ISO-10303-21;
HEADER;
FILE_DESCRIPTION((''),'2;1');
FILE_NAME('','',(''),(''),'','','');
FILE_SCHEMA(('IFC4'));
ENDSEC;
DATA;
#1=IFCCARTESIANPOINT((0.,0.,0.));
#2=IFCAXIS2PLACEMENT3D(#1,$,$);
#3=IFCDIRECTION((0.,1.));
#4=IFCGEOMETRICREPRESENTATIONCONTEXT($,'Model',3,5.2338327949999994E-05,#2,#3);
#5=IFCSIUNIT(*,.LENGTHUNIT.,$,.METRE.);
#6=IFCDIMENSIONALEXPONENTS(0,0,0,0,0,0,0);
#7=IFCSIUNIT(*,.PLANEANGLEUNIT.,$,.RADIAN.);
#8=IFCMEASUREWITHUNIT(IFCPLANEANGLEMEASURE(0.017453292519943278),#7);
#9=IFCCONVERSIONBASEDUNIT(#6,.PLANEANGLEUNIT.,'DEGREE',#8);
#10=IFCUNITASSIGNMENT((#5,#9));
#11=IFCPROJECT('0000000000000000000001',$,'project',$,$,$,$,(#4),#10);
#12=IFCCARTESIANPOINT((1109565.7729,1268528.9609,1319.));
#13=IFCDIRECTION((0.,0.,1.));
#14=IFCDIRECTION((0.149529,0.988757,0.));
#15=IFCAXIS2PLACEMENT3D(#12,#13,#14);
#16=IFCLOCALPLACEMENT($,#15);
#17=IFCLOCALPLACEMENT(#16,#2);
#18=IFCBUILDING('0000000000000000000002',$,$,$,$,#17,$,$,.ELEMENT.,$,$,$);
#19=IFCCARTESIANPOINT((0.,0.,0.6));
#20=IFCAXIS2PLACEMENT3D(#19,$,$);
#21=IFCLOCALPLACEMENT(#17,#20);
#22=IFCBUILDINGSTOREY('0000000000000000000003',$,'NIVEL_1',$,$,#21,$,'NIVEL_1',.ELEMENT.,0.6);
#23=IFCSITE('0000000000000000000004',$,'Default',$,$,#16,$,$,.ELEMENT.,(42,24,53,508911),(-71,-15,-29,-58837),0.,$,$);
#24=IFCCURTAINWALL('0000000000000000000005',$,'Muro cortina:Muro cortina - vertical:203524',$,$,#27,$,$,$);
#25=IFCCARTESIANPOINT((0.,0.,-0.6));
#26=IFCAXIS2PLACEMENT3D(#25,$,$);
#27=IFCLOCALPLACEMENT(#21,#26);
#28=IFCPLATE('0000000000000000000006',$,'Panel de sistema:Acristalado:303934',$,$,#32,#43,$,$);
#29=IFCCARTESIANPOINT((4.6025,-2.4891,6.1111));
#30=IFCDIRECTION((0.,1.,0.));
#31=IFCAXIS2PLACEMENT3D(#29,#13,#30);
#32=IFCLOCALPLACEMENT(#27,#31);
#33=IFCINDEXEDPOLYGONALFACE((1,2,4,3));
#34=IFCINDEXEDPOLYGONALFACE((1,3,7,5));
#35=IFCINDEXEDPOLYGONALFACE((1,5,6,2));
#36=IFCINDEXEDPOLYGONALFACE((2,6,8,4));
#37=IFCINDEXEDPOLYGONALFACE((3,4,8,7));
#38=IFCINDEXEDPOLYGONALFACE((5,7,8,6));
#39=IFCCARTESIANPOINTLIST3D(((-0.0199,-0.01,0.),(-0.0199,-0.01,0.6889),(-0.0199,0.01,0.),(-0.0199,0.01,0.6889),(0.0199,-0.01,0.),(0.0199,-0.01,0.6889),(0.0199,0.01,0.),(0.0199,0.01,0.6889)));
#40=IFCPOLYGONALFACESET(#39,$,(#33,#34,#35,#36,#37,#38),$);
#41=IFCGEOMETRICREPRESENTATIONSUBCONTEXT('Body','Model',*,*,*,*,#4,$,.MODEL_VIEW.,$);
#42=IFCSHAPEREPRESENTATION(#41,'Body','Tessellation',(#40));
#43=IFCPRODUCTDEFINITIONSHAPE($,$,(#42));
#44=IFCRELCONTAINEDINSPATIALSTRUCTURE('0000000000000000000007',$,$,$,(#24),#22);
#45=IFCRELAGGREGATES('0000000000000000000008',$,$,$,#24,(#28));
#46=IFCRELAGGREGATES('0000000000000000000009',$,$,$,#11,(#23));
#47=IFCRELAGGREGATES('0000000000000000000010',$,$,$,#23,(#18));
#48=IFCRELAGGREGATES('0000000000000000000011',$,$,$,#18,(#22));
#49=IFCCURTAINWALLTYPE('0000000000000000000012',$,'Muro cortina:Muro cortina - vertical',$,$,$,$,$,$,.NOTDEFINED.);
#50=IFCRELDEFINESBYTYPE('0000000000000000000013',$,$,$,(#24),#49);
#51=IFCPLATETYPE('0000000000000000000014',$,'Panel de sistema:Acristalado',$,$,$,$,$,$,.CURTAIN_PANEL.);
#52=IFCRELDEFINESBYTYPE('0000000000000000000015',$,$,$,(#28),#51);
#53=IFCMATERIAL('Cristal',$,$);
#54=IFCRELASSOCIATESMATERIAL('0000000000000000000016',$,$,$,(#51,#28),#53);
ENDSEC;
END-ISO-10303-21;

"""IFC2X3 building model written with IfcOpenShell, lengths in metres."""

from ifc_helpers import new_model, entity, si_unit, converted_unit, direction, frame, origin, origin_2d_with_axis, place, context, subcontext, project, spatial, rectangle, extrude, source, transform, mapped, material, type_object, type_shapes, element, aggregate, save


model = new_model("IFC2X3")

# Units and contexts
model_context = context("Model", 3, precision=5.2338327949999994e-05, world=origin(), true_north=direction((0.0, 1.0)))
body_context = subcontext(model_context, "Body", "Model", "MODEL_VIEW")
ifc_project = project(units=[si_unit("LENGTHUNIT", "METRE"), converted_unit("PLANEANGLEUNIT", "DEGREE", entity("IfcPlaneAngleMeasure", 0.017453292519943278), si_unit("PLANEANGLEUNIT", "RADIAN"), dimensions=[0, 0, 0, 0, 0, 0, 0])], contexts=[model_context])

# Site, building, storey
site_placement = place(None, frame((1109565.7729, 1268528.9609, 1319.0), z_axis=(0.0, 0.0, 1.0), x_axis=(0.149529, 0.988757, 0.0)))
site = spatial("IfcSite", under=ifc_project, at=site_placement, Name="Default", CompositionType="ELEMENT", RefLatitude=(42, 24, 53, 508911), RefLongitude=(-71, -15, -29, -58837), RefElevation=0.0)
building_placement = place(site_placement, origin())
building = spatial("IfcBuilding", under=site, at=building_placement, CompositionType="ELEMENT")
storey_placement = place(building_placement, frame((0.0, 0.0, 0.6)))
storey = spatial("IfcBuildingStorey", under=building, at=storey_placement, Name="NIVEL_1", LongName="NIVEL_1", CompositionType="ELEMENT", Elevation=0.6)

# Shared definitions
curtain_wall_type = type_object("IfcCurtainWallType", Name="Muro cortina:Muro cortina - vertical", PredefinedType="NOTDEFINED")
ifc_material_1 = material(Name="Cristal")

# Curtain wall, plate
curtain_wall_1_placement = place(storey_placement, frame((0.0, 0.0, -0.6)))
curtain_wall_1 = element("IfcCurtainWall", 1, at=curtain_wall_1_placement, inside=storey, type_object=curtain_wall_type, Name="Muro cortina:Muro cortina - vertical:203524")
plate_type_1 = type_object("IfcPlateType", Name="Panel de sistema:Acristalado", PredefinedType="CURTAIN_PANEL", material=ifc_material_1)
shared_shape_1 = source(origin(), body_context, "Body", "SweptSolid", [
    extrude(rectangle(XDim=0.02, YDim=0.0398, at=origin_2d_with_axis()), frame((0.0, 0.0, 0.0), z_axis=(0.0, 0.0, 1.0), x_axis=(0.0, 1.0, 0.0)), (0.0, 0.0, 1.0), 0.6889),
])
type_shapes(plate_type_1, [shared_shape_1])
plate_1_placement = place(curtain_wall_1_placement, frame((4.6025, -2.4891, 6.1111), z_axis=(0.0, 0.0, 1.0), x_axis=(0.0, 1.0, 0.0)))
plate_1 = element("IfcPlate", 2, at=plate_1_placement, type_object=plate_type_1, material=ifc_material_1, Name="Panel de sistema:Acristalado:303934", context=body_context, shape_type="MappedRepresentation", body=[
    mapped(shared_shape_1, transform((0.0, 0.0, 0.0), scale=1.0)),
])
aggregate(curtain_wall_1, [plate_1])

save(model, "model.ifc")
